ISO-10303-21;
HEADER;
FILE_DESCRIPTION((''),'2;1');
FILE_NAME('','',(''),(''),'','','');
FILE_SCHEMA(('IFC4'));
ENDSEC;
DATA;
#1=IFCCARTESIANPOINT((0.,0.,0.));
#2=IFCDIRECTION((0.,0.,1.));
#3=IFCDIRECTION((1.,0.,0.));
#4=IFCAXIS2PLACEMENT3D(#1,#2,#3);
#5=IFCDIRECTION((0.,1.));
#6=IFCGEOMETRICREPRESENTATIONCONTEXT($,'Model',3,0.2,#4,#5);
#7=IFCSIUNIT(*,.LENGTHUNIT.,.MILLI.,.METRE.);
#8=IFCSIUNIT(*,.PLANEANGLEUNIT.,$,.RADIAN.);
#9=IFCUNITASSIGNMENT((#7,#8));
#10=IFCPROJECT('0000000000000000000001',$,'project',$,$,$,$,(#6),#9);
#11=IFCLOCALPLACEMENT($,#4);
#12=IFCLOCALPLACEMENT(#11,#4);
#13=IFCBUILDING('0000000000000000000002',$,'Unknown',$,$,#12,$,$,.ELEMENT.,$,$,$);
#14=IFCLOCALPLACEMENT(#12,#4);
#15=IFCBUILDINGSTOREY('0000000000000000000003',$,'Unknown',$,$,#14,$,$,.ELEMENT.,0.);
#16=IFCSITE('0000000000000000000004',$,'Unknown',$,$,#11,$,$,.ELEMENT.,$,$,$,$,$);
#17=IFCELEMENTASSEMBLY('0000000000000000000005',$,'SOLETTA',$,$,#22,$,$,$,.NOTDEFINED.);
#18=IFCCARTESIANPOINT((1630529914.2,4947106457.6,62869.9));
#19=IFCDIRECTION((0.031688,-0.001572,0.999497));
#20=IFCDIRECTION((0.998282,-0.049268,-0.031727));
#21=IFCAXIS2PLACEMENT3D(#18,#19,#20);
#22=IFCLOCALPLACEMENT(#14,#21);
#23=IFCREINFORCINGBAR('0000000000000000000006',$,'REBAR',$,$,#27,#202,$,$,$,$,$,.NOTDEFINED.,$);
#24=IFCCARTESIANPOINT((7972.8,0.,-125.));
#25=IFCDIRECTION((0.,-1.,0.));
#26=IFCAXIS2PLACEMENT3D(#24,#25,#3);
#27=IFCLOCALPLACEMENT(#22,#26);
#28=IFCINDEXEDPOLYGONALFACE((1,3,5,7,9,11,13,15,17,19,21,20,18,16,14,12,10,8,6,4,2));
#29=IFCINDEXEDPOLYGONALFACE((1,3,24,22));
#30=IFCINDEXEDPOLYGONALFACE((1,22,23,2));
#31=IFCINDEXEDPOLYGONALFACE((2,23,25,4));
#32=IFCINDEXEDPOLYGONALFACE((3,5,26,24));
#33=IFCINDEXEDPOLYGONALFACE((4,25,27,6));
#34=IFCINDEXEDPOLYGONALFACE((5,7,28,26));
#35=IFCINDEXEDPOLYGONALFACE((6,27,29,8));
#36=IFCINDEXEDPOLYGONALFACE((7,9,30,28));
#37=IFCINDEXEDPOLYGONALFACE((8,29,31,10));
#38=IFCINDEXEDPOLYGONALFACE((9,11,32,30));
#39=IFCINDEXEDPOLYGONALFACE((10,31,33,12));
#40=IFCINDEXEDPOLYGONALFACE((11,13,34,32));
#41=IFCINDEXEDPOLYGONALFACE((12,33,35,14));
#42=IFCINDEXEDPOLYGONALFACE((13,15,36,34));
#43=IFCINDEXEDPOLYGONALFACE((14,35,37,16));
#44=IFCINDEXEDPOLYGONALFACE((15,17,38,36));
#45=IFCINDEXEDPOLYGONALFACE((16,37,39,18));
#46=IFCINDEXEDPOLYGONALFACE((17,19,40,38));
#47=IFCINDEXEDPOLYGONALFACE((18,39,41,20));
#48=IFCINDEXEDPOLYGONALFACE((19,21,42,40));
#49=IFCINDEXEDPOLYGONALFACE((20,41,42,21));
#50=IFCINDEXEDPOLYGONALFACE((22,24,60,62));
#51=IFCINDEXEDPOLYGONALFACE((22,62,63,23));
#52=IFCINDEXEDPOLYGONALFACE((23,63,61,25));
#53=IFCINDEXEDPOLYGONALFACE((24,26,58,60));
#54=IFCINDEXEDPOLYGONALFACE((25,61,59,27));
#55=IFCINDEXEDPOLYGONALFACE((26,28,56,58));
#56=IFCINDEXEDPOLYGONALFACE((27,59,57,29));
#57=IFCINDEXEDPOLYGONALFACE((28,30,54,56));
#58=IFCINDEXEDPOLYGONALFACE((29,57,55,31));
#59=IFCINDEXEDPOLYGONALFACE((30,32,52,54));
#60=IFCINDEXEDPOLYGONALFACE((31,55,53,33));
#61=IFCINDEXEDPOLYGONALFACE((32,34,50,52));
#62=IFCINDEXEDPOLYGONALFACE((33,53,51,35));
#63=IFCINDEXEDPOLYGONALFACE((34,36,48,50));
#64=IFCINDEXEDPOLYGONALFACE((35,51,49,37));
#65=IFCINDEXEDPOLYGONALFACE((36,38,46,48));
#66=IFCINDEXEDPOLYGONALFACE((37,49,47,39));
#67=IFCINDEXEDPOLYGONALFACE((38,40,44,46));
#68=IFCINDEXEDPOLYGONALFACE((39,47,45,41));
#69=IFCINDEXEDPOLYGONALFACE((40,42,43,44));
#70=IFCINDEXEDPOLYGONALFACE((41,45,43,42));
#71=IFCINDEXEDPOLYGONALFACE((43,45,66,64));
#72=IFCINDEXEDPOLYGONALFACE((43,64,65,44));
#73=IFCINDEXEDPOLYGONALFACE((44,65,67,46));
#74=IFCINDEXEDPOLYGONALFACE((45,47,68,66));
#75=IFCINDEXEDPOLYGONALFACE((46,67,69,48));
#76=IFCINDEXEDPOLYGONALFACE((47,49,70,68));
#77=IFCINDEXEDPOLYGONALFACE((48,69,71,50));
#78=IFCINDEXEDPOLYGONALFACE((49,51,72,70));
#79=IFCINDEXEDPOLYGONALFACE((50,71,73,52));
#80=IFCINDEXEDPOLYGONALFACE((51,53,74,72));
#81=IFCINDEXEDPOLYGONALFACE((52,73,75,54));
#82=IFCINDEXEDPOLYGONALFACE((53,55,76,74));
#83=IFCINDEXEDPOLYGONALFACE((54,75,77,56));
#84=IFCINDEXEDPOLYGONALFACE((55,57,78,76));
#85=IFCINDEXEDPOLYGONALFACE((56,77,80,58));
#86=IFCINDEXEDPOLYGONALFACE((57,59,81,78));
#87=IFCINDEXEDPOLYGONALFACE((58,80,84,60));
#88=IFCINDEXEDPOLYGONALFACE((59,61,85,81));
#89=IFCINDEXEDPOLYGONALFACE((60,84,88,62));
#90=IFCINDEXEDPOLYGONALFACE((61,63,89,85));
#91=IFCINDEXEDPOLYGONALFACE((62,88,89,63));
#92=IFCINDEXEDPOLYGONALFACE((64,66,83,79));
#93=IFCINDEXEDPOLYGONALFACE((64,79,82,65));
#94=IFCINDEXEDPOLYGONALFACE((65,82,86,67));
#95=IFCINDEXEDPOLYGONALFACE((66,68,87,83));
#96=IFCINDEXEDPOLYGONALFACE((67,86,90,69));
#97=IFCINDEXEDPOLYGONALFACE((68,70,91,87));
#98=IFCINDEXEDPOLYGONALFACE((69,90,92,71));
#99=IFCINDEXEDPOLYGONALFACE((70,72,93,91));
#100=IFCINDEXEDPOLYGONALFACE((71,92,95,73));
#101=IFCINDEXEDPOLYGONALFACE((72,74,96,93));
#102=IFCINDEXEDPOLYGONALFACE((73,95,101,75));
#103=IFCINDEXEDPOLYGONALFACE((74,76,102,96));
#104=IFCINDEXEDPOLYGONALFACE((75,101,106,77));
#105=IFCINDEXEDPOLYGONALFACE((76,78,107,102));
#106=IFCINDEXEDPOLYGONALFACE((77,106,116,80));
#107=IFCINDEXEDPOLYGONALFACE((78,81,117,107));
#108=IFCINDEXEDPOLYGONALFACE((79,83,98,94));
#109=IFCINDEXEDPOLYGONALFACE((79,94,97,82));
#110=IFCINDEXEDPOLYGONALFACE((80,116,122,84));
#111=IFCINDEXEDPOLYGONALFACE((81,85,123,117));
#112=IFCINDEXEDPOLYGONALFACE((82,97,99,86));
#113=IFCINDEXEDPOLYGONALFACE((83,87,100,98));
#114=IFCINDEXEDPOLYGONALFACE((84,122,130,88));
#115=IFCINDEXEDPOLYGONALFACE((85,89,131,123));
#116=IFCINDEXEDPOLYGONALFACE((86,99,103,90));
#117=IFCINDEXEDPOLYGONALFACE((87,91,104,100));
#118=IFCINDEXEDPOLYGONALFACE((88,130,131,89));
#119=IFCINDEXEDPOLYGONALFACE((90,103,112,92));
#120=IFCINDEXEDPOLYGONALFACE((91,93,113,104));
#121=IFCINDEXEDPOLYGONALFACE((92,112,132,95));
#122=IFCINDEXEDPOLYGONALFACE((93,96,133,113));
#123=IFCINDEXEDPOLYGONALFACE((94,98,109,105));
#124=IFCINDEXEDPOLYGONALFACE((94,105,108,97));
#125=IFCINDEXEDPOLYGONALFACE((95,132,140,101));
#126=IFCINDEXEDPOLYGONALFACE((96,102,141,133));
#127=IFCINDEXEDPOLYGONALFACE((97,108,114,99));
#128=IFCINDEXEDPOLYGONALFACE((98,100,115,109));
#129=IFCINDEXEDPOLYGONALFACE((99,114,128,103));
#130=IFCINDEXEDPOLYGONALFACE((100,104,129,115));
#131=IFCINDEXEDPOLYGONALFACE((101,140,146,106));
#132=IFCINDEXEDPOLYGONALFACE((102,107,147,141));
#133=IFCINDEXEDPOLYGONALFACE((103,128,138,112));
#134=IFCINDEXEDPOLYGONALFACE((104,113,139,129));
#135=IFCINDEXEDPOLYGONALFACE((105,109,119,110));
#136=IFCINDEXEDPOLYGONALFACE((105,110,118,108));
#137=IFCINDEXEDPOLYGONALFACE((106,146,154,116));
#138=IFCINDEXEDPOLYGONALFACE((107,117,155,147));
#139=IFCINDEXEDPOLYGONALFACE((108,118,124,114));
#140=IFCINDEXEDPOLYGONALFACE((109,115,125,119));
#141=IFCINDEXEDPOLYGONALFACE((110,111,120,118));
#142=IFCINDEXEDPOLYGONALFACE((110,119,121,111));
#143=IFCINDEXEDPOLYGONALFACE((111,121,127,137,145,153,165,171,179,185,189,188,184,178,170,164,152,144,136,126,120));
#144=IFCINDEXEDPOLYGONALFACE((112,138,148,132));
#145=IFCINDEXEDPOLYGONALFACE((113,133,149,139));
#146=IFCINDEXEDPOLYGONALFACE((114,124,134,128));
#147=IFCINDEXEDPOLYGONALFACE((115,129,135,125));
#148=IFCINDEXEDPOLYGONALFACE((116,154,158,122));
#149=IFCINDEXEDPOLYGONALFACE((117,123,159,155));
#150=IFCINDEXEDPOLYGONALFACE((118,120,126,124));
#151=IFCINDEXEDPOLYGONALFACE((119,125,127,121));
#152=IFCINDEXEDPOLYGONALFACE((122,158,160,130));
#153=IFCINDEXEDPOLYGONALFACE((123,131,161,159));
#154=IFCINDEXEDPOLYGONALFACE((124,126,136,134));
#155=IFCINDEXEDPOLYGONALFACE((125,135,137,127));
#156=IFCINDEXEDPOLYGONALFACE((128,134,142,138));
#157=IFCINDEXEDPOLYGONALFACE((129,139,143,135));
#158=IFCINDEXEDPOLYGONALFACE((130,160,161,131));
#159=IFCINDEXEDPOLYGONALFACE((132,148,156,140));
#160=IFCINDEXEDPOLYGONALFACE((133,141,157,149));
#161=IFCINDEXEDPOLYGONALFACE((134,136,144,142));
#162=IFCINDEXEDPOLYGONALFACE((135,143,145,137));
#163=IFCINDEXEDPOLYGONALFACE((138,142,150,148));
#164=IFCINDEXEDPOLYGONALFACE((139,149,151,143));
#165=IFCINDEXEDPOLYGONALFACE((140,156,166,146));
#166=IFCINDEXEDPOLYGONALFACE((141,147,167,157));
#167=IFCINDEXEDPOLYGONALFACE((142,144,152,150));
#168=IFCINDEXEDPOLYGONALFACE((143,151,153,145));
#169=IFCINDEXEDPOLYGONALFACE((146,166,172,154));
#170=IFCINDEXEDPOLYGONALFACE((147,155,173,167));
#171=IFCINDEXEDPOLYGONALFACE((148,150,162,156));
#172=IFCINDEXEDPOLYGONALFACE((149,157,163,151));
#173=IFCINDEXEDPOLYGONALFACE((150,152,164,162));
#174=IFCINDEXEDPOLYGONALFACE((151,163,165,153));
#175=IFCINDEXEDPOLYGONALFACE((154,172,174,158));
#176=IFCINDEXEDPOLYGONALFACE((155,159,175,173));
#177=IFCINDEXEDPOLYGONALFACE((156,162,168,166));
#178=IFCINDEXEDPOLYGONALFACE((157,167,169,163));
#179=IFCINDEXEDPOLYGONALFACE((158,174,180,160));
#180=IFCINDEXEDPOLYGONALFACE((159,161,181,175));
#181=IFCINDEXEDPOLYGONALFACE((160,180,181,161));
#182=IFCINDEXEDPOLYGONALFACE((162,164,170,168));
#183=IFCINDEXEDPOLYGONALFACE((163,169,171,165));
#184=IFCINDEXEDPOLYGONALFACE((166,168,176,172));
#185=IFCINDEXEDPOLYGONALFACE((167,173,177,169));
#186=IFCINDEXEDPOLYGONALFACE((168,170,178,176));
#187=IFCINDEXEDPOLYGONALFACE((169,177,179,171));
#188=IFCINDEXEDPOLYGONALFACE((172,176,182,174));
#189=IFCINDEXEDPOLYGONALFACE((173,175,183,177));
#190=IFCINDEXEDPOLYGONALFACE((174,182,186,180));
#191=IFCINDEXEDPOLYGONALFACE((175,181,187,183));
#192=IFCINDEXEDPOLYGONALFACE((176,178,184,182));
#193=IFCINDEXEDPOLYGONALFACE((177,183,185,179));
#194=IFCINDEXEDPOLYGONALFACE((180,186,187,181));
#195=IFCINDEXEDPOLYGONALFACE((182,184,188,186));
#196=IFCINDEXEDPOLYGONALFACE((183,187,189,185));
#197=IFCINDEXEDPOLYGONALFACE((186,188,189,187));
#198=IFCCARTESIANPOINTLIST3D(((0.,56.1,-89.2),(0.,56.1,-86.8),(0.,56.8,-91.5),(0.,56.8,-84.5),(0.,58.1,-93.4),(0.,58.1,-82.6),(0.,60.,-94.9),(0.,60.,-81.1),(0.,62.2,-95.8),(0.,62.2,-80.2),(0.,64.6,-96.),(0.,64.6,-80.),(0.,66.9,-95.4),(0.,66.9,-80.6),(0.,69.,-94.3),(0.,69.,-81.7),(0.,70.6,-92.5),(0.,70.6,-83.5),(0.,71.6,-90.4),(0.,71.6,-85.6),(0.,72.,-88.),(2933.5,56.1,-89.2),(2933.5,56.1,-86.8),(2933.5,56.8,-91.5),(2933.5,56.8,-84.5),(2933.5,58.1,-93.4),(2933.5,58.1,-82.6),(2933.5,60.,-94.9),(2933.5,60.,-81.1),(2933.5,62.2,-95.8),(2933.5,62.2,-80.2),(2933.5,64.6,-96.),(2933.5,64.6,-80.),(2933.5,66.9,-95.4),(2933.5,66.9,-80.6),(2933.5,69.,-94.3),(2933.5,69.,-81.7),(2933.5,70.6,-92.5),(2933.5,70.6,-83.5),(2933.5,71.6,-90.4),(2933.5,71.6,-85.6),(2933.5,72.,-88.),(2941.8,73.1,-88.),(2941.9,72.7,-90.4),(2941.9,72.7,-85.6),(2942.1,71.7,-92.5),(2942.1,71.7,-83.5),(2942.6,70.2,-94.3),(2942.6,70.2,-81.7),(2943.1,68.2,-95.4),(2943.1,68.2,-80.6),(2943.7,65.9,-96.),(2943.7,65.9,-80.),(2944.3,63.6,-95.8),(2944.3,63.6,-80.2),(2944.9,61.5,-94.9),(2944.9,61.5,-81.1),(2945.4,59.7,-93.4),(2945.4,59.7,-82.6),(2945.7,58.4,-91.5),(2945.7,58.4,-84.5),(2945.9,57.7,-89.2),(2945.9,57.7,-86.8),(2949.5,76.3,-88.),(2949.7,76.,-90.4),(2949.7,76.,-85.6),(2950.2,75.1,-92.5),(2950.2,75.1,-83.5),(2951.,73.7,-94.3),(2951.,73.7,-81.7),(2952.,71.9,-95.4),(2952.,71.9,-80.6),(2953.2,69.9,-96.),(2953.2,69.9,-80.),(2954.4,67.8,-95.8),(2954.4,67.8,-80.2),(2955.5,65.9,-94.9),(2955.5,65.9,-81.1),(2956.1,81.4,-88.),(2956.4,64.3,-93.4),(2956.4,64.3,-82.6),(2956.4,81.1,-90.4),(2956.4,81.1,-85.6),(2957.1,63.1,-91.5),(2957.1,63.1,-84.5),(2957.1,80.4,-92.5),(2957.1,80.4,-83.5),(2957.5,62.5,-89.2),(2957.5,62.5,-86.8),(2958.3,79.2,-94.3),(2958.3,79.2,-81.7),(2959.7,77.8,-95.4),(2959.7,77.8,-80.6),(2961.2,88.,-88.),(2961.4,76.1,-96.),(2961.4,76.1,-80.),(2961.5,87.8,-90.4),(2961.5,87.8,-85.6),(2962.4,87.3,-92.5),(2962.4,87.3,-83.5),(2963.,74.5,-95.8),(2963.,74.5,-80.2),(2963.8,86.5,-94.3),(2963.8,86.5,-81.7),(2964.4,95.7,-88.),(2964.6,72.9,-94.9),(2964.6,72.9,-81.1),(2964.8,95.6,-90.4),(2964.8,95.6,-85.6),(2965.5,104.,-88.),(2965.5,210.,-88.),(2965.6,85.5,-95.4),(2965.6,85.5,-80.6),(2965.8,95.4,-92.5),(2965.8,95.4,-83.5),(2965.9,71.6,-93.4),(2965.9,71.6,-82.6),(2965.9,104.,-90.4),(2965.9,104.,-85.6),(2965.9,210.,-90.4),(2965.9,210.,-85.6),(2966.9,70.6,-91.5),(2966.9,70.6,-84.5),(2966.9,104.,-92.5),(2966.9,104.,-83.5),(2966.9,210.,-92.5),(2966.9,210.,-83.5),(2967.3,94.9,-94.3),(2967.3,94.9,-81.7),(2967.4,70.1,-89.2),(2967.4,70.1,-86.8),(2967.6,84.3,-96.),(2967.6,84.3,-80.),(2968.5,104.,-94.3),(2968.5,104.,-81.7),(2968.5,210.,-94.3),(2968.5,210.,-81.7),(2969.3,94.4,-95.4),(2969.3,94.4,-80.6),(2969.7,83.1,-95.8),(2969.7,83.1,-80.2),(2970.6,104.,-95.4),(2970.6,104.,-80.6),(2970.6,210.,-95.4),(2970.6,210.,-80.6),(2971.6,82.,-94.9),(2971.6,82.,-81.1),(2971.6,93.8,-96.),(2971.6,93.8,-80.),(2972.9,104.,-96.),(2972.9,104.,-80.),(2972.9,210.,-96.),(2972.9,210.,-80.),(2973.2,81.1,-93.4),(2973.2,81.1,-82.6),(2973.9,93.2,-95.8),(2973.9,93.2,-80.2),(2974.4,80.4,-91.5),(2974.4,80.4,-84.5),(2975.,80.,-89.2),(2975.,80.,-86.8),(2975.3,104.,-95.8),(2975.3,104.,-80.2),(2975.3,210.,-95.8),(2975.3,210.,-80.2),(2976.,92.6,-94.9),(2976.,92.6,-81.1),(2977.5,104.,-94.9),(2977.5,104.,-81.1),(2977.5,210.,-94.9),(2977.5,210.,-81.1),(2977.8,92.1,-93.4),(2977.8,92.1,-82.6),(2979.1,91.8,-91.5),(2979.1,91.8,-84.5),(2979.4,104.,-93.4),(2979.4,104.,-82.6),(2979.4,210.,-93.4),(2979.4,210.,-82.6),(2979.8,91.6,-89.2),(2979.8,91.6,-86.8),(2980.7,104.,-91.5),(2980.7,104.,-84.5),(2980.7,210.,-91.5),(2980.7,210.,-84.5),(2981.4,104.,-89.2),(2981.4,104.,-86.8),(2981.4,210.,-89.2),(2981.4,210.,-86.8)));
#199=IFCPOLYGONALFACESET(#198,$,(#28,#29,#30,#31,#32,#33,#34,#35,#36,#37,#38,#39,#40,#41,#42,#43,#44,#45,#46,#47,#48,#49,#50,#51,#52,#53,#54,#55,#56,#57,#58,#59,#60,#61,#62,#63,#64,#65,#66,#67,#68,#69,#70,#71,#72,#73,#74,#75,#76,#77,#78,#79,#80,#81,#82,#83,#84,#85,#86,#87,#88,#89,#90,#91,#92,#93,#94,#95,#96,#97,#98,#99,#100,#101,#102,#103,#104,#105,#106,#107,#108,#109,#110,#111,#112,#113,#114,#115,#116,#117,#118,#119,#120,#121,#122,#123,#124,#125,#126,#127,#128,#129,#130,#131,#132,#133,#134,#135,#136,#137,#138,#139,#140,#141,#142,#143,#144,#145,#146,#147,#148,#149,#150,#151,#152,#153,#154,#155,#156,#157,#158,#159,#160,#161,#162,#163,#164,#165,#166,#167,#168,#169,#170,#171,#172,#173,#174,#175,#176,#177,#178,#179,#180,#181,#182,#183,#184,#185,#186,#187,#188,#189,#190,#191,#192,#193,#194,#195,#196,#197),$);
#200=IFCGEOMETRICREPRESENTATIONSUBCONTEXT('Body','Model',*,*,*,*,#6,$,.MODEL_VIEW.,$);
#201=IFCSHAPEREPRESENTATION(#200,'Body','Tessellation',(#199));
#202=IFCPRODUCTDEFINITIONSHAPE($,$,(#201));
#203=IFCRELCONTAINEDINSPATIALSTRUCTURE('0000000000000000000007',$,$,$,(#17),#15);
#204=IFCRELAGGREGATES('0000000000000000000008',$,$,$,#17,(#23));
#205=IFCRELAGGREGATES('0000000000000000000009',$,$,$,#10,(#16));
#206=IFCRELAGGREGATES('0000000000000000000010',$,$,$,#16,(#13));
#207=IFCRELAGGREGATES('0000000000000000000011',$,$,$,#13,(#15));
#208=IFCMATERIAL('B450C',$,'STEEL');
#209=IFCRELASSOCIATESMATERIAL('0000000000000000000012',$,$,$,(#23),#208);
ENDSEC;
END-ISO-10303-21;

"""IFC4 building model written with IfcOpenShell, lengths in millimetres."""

from ifc_helpers import new_model, entity, si_unit, direction, frame, origin_with_axes, place, context, subcontext, project, spatial, material, element, aggregate, save


model = new_model("IFC4")

# Units and contexts
model_context = context("Model", 3, precision=0.2, world=origin_with_axes(), true_north=direction((0.0, 1.0)))
body_context = subcontext(model_context, "Body", "Model", "MODEL_VIEW")
ifc_project = project(units=[si_unit("LENGTHUNIT", "METRE", prefix="MILLI"), si_unit("PLANEANGLEUNIT", "RADIAN")], contexts=[model_context])

# Site, building, storey
site_placement = place(None, origin_with_axes())
site = spatial("IfcSite", under=ifc_project, at=site_placement, Name="Unknown", CompositionType="ELEMENT")
building_placement = place(site_placement, origin_with_axes())
building = spatial("IfcBuilding", under=site, at=building_placement, Name="Unknown", CompositionType="ELEMENT")
storey_placement = place(building_placement, origin_with_axes())
storey = spatial("IfcBuildingStorey", under=building, at=storey_placement, Name="Unknown", CompositionType="ELEMENT", Elevation=0.0)

# Element assembly
ifc_material = material(Name="B450C", Category="STEEL")
assembly_1_placement = place(storey_placement, frame((1630529914.2, 4947106457.6, 62869.9), z_axis=(0.031688, -0.001572, 0.999497), x_axis=(0.998282, -0.049268, -0.031727)))
assembly_1 = element("IfcElementAssembly", 1, at=assembly_1_placement, inside=storey, Name="SOLETTA", PredefinedType="NOTDEFINED")

# Reinforcing bar
reinforcing_bar_1_placement = place(assembly_1_placement, frame((7972.8, 0.0, -125.0), z_axis=(0.0, -1.0, 0.0), x_axis=(1.0, 0.0, 0.0)))
reinforcing_bar_1 = element("IfcReinforcingBar", 2, at=reinforcing_bar_1_placement, material=ifc_material, Name="REBAR", PredefinedType="NOTDEFINED", context=body_context, shape_type="AdvancedSweptSolid", body=[
    entity("IfcSweptDiskSolid", entity("IfcIndexedPolyCurve", entity("IfcCartesianPointList3D", [[0.0, 64.0, -88.0], [2933.5, 64.0, -88.0], [2961.8, 75.7, -88.0], [2973.5, 104.0, -88.0], [2973.5, 210.0, -88.0]]), [entity("IfcLineIndex", [1, 2]), entity("IfcArcIndex", [2, 3, 4]), entity("IfcLineIndex", [4, 5])]), 8.0),
])
aggregate(assembly_1, [reinforcing_bar_1])

save(model, "model.ifc")
